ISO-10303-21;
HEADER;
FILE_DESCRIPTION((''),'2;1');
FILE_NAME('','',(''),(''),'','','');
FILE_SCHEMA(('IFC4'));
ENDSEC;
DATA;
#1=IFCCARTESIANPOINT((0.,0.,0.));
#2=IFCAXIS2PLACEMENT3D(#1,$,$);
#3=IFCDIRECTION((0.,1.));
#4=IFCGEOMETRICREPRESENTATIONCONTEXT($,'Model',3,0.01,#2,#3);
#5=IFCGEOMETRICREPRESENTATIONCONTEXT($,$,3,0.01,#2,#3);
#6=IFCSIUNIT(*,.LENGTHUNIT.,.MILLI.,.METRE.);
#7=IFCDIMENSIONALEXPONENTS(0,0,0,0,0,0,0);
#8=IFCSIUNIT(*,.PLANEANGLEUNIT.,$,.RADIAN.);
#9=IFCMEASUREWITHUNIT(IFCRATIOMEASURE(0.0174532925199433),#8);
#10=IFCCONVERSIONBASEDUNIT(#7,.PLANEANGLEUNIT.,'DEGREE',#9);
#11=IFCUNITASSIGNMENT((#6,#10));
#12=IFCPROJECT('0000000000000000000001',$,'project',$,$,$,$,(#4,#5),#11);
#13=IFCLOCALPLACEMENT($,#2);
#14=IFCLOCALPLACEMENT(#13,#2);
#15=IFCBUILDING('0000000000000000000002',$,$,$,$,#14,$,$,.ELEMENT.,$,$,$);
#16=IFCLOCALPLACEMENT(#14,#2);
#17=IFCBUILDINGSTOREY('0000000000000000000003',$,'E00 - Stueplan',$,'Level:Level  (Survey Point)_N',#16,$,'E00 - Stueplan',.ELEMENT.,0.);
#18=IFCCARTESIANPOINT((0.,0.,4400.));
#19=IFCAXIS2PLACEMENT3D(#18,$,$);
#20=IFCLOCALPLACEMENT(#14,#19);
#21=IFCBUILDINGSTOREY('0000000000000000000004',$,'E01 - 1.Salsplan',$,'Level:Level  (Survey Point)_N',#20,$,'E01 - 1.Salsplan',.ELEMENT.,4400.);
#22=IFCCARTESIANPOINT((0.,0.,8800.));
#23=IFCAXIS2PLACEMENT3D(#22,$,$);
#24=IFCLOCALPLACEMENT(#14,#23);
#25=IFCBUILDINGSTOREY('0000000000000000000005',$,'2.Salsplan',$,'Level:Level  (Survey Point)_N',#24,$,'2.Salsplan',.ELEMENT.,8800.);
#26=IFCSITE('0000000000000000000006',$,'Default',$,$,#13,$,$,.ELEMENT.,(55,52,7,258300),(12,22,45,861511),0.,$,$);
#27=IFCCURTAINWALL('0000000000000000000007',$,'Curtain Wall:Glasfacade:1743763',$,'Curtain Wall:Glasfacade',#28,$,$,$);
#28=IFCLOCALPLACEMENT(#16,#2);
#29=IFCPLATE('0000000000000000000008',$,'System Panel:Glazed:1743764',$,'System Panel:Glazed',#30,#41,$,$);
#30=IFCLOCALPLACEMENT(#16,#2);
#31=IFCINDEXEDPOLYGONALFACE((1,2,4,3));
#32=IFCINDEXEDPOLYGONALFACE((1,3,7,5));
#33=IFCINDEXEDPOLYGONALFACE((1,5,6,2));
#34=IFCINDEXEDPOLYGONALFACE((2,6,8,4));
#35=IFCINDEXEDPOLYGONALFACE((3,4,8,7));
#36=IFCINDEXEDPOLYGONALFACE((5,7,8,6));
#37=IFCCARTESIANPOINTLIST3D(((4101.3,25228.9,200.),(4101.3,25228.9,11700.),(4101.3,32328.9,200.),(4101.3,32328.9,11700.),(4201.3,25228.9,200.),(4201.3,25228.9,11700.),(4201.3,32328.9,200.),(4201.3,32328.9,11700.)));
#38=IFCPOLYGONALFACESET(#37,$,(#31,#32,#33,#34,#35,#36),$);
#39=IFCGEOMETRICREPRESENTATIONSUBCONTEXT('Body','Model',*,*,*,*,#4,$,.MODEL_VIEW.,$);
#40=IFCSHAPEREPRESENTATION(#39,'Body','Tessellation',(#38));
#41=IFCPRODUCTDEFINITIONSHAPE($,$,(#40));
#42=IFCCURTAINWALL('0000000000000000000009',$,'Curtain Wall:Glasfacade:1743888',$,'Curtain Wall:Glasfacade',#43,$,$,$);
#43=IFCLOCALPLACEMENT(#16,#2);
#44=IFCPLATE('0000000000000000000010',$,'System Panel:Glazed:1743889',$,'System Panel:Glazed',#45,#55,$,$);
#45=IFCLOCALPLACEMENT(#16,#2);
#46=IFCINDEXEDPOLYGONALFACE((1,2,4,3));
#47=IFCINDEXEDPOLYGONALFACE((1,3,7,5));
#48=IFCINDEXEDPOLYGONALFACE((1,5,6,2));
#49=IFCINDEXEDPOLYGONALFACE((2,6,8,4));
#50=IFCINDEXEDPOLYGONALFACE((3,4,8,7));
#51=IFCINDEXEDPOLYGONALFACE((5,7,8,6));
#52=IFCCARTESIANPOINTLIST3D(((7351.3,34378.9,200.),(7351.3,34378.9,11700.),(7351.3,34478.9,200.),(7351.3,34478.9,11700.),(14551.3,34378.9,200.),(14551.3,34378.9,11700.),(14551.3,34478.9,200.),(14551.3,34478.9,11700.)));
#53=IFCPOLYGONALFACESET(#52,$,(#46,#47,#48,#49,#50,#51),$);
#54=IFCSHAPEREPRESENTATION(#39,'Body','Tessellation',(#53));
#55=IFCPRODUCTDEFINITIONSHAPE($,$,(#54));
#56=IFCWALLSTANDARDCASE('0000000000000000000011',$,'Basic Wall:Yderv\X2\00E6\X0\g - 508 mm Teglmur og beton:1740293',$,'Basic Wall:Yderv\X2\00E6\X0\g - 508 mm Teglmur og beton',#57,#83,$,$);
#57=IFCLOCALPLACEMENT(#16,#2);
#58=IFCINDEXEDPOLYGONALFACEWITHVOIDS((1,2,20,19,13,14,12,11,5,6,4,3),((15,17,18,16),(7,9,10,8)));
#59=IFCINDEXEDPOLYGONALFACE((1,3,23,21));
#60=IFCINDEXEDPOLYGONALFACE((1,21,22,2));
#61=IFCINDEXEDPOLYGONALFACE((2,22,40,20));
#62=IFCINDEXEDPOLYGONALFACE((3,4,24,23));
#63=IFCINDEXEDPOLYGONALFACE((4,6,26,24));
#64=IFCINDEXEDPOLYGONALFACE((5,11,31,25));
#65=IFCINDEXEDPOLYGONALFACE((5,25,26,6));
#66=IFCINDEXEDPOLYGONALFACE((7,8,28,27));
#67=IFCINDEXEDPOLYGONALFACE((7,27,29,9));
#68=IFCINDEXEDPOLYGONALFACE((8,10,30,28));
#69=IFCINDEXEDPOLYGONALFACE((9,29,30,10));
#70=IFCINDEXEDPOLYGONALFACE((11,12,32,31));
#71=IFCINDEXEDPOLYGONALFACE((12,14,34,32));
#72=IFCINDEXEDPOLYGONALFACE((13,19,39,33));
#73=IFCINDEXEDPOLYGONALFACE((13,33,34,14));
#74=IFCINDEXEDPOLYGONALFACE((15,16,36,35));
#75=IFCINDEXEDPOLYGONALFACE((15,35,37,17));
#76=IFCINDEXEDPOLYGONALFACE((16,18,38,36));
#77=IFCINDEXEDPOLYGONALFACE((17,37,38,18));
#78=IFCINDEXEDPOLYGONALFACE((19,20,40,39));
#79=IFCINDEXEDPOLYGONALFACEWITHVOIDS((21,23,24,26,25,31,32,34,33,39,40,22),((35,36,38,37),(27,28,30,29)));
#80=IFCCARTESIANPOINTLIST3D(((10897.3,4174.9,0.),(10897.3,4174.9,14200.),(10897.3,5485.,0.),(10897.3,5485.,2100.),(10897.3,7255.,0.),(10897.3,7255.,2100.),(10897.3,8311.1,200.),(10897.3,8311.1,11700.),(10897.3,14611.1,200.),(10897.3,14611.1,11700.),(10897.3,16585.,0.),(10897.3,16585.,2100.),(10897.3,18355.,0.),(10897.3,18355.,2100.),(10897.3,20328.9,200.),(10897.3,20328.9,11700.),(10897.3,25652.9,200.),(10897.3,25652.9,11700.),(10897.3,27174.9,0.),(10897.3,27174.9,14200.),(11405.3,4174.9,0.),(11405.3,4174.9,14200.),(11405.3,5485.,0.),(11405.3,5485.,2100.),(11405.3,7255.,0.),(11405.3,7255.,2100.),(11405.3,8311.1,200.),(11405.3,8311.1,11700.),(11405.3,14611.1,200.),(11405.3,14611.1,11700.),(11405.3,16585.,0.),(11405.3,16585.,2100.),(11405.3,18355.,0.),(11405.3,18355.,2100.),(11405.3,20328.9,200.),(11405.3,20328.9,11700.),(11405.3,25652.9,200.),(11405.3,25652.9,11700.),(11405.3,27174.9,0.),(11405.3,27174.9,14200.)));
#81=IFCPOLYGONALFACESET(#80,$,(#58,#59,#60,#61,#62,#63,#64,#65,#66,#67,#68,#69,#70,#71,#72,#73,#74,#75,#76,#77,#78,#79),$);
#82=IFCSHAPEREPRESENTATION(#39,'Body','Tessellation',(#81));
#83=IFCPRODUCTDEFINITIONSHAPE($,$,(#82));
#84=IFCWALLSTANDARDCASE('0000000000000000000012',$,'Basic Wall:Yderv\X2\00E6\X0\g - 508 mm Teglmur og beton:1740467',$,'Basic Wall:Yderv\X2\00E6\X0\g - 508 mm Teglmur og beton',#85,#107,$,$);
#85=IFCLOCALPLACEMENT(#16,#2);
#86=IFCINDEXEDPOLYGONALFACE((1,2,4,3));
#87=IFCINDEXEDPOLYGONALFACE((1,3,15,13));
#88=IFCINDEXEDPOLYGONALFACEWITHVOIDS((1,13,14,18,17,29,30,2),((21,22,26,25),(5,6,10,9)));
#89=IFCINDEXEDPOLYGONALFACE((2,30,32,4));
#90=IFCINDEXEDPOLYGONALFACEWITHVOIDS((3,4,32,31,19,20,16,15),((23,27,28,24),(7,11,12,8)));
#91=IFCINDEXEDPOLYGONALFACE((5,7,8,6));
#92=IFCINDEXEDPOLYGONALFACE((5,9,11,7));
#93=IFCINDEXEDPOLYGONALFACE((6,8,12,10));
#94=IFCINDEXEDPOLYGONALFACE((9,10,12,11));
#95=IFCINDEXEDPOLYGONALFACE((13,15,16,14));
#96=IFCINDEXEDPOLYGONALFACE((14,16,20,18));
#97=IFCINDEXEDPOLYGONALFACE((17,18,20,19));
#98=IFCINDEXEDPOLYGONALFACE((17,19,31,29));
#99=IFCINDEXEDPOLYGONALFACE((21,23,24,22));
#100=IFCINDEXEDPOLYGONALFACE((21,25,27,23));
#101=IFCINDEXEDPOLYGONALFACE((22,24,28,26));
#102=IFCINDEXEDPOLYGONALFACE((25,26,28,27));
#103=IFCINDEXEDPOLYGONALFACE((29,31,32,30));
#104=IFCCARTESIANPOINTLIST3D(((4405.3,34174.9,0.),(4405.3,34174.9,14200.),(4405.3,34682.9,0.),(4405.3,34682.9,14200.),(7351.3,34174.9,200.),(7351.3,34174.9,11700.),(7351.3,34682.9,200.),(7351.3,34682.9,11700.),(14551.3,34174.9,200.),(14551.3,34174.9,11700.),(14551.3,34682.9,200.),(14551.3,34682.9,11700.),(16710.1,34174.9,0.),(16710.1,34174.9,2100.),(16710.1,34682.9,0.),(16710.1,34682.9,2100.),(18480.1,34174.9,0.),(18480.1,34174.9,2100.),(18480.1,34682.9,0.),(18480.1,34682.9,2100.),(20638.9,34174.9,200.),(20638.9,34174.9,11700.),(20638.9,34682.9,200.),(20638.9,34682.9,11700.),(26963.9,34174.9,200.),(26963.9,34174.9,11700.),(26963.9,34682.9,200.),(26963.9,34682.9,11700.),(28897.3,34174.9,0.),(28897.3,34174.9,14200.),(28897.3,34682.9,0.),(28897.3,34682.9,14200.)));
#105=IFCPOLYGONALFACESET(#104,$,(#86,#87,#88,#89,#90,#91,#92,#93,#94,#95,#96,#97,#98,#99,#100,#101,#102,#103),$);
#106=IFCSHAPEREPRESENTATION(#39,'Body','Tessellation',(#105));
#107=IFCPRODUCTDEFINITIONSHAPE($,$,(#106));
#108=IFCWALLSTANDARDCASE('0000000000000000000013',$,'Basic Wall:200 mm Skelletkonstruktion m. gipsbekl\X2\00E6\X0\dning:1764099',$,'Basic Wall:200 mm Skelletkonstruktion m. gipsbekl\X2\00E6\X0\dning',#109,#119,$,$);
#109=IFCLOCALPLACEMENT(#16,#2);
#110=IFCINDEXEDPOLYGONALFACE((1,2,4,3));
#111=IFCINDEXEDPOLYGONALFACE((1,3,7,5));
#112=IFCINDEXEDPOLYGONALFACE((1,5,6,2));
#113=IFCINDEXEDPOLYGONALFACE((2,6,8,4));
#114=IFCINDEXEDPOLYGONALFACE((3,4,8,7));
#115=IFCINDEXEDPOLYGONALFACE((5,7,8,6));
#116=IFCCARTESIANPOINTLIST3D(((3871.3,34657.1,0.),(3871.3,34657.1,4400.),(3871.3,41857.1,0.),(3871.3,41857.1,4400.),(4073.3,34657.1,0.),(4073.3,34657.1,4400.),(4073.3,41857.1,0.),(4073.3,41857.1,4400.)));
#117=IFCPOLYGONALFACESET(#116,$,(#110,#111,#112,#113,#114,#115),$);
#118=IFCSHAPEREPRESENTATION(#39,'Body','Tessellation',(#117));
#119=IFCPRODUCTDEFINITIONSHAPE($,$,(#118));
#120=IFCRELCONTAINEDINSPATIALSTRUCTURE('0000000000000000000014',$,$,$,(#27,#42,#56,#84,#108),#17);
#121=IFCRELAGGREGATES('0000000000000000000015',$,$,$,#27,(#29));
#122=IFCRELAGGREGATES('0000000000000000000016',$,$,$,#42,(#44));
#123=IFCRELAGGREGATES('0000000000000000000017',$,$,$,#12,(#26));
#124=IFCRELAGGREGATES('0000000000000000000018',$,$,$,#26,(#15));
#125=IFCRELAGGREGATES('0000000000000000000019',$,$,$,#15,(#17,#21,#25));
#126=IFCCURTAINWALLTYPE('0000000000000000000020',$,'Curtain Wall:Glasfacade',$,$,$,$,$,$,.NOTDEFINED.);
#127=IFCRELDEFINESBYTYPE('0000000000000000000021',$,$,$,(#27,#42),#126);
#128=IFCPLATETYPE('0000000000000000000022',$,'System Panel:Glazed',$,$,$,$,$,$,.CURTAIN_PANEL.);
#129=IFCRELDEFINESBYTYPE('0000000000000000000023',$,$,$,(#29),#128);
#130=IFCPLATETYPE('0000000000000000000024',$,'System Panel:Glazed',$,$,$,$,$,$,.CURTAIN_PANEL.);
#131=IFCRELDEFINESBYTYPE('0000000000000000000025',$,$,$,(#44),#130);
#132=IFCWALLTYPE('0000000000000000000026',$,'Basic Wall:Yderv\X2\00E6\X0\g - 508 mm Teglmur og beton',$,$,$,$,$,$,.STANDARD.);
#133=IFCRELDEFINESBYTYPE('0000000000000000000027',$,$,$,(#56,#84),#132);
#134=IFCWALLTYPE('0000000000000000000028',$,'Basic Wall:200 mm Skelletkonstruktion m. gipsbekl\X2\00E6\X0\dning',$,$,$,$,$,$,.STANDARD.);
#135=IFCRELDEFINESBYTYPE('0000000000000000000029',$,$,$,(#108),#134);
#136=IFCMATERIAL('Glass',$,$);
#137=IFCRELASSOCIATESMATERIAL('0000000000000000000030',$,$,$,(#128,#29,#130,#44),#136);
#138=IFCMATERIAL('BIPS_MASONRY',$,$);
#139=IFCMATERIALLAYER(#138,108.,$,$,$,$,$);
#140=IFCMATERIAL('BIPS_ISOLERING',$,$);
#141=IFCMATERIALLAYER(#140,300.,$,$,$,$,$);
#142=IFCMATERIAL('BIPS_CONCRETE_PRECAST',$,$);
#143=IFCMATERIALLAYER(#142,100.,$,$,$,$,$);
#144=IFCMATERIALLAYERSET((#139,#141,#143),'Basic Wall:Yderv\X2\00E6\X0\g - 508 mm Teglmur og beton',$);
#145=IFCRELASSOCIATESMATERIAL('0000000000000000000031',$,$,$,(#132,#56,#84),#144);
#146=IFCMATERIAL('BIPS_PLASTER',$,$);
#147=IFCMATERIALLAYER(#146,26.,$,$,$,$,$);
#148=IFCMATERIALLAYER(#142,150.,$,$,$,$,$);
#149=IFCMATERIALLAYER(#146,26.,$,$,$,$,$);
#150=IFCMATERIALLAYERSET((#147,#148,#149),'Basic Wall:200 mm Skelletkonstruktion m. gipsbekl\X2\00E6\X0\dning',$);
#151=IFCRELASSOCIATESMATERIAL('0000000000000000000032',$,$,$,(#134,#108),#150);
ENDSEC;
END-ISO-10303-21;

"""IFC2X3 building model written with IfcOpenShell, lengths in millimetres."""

from ifc_helpers import new_model, entity, si_unit, converted_unit, direction, frame, frame_2d, origin, origin_2d_with_axis, place, context, subcontext, project, spatial, rectangle, extrude, source, transform, mapped, material, layer, layer_set, layer_usage, type_object, type_shapes, element, aggregate, save


model = new_model("IFC2X3")

# Units and contexts
model_context = context("Model", 3, precision=0.01, world=origin(), true_north=direction((0.0, 1.0)))
context_of_model = context(None, 3, precision=0.01, world=origin(), true_north=direction((0.0, 1.0)))
body_context = subcontext(model_context, "Body", "Model", "MODEL_VIEW")
ifc_project = project(units=[si_unit("LENGTHUNIT", "METRE", prefix="MILLI"), converted_unit("PLANEANGLEUNIT", "DEGREE", entity("IfcRatioMeasure", 0.0174532925199433), si_unit("PLANEANGLEUNIT", "RADIAN"), dimensions=[0, 0, 0, 0, 0, 0, 0])], contexts=[model_context, context_of_model])

# Site, building, storey
site_placement = place(None, origin())
site = spatial("IfcSite", under=ifc_project, at=site_placement, Name="Default", CompositionType="ELEMENT", RefLatitude=(55, 52, 7, 258300), RefLongitude=(12, 22, 45, 861511), RefElevation=0.0)
building_placement = place(site_placement, origin())
building = spatial("IfcBuilding", under=site, at=building_placement, CompositionType="ELEMENT")
storey_1_placement = place(building_placement, origin())
storey_1 = spatial("IfcBuildingStorey", under=building, at=storey_1_placement, Name="E00 - Stueplan", ObjectType="Level:Level  (Survey Point)_N", LongName="E00 - Stueplan", CompositionType="ELEMENT", Elevation=0.0)

# Curtain walls, plates
curtain_wall_type = type_object("IfcCurtainWallType", Name="Curtain Wall:Glasfacade", PredefinedType="NOTDEFINED")
curtain_wall_1_placement = place(storey_1_placement, origin())
curtain_wall_1 = element("IfcCurtainWall", 1, at=curtain_wall_1_placement, inside=storey_1, type_object=curtain_wall_type, Name="Curtain Wall:Glasfacade:1743763", ObjectType="Curtain Wall:Glasfacade")
ifc_material_1 = material(Name="Glass")
plate_type_1 = type_object("IfcPlateType", Name="System Panel:Glazed", PredefinedType="CURTAIN_PANEL", material=ifc_material_1)
shared_shape_1 = source(origin(), body_context, "Body", "SweptSolid", [
    extrude(rectangle(XDim=100.0, YDim=7100.0, at=origin_2d_with_axis()), frame((0.0, 0.0, 0.0), z_axis=(0.0, 0.0, 1.0), x_axis=(0.0, 1.0, 0.0)), (0.0, 0.0, 1.0), 11500.0),
])
type_shapes(plate_type_1, [shared_shape_1])
plate_1_placement = place(curtain_wall_1_placement, frame((4151.3, 28778.9, 200.0), z_axis=(0.0, 0.0, 1.0), x_axis=(0.0, -1.0, 0.0)))
plate_1 = element("IfcPlate", 2, at=plate_1_placement, type_object=plate_type_1, material=ifc_material_1, Name="System Panel:Glazed:1743764", ObjectType="System Panel:Glazed", context=body_context, shape_type="MappedRepresentation", body=[
    mapped(shared_shape_1, transform((0.0, 0.0, 0.0), scale=1.0)),
])
aggregate(curtain_wall_1, [plate_1])
curtain_wall_2_placement = place(storey_1_placement, origin())
curtain_wall_2 = element("IfcCurtainWall", 3, at=curtain_wall_2_placement, inside=storey_1, type_object=curtain_wall_type, Name="Curtain Wall:Glasfacade:1743888", ObjectType="Curtain Wall:Glasfacade")
plate_type_2 = type_object("IfcPlateType", Name="System Panel:Glazed", PredefinedType="CURTAIN_PANEL", material=ifc_material_1)
shared_shape_2 = source(origin(), body_context, "Body", "SweptSolid", [
    extrude(rectangle(XDim=100.0, YDim=7200.0, at=origin_2d_with_axis()), frame((0.0, 0.0, 0.0), z_axis=(0.0, 0.0, 1.0), x_axis=(0.0, 1.0, 0.0)), (0.0, 0.0, 1.0), 11500.0),
])
type_shapes(plate_type_2, [shared_shape_2])
plate_2_placement = place(curtain_wall_2_placement, frame((10951.3, 34428.9, 200.0)))
plate_2 = element("IfcPlate", 4, at=plate_2_placement, type_object=plate_type_2, material=ifc_material_1, Name="System Panel:Glazed:1743889", ObjectType="System Panel:Glazed", context=body_context, shape_type="MappedRepresentation", body=[
    mapped(shared_shape_2, transform((0.0, 0.0, 0.0), scale=1.0)),
])
aggregate(curtain_wall_2, [plate_2])

# Shared definitions
ifc_material_2 = material(Name="BIPS_MASONRY")
ifc_layer_1 = layer(ifc_material_2, 108.0)
ifc_material_3 = material(Name="BIPS_ISOLERING")
ifc_layer_2 = layer(ifc_material_3, 300.0)
ifc_material_4 = material(Name="BIPS_CONCRETE_PRECAST")
ifc_layer_3 = layer(ifc_material_4, 100.0)
ifc_layer_set_1 = layer_set([ifc_layer_1, ifc_layer_2, ifc_layer_3], Name="Basic Wall:Ydervæg - 508 mm Teglmur og beton")
wall_type_1 = type_object("IfcWallType", Name="Basic Wall:Ydervæg - 508 mm Teglmur og beton", PredefinedType="STANDARD", material=ifc_layer_set_1)

# Shared definitions
storey_2_placement = place(building_placement, frame((0.0, 0.0, 4400.0)))
storey_2 = spatial("IfcBuildingStorey", under=building, at=storey_2_placement, Name="E01 - 1.Salsplan", ObjectType="Level:Level  (Survey Point)_N", LongName="E01 - 1.Salsplan", CompositionType="ELEMENT", Elevation=4400.0)

# Shared definitions
storey_3_placement = place(building_placement, frame((0.0, 0.0, 8800.0)))
storey_3 = spatial("IfcBuildingStorey", under=building, at=storey_3_placement, Name="2.Salsplan", ObjectType="Level:Level  (Survey Point)_N", LongName="2.Salsplan", CompositionType="ELEMENT", Elevation=8800.0)

# Walls, openings
ifc_layer_usage_1 = layer_usage(ifc_layer_set_1, "AXIS2", "POSITIVE", -254.0)
wall_1_placement = place(storey_1_placement, frame((11151.3, 27174.9, 0.0), z_axis=(0.0, 0.0, 1.0), x_axis=(0.0, -1.0, 0.0)))
wall_1 = element("IfcWallStandardCase", 5, at=wall_1_placement, inside=storey_1, type_object=wall_type_1, material=ifc_layer_usage_1, Name="Basic Wall:Ydervæg - 508 mm Teglmur og beton:1740293", ObjectType="Basic Wall:Ydervæg - 508 mm Teglmur og beton", context=body_context, shape_type="SweptSolid", body=[
    extrude(rectangle(XDim=23000.0, YDim=508.0, at=frame_2d((11500.0, 0.0), x_axis=(-1.0, 0.0))), origin(), (0.0, 0.0, 1.0), 14200.0),
])
opening_1_placement = place(wall_1_placement, origin())
element("IfcOpeningElement", 6, at=opening_1_placement, cuts=wall_1, ObjectType="Opening", context=body_context, shape_type="SweptSolid", body=[
    extrude(rectangle(XDim=11500.0, YDim=5324.0, at=frame_2d((0.0, 0.0), x_axis=(1.0, 0.0))), frame((4184.0, -406.4, 5950.0), z_axis=(0.0, 1.0, 0.0), x_axis=(0.0, 0.0, 1.0)), (0.0, 0.0, 1.0), 812.8),
])
opening_2_placement = place(wall_1_placement, origin())
element("IfcOpeningElement", 7, at=opening_2_placement, cuts=wall_1, ObjectType="Opening", context=body_context, shape_type="SweptSolid", body=[
    extrude(rectangle(XDim=11500.0, YDim=6300.0, at=frame_2d((0.0, 0.0), x_axis=(1.0, 0.0))), frame((15713.7, -406.4, 5950.0), z_axis=(0.0, 1.0, 0.0), x_axis=(0.0, 0.0, 1.0)), (0.0, 0.0, 1.0), 812.8),
])
opening_3_placement = place(wall_1_placement, frame((21689.9, 254.0, 0.0)))
element("IfcOpeningElement", 8, at=opening_3_placement, cuts=wall_1, ObjectType="Opening", context=body_context, shape_type="SweptSolid", body=[
    extrude(rectangle(XDim=2100.0, YDim=1770.0, at=frame_2d((1050.0, 885.0), x_axis=(1.0, 0.0))), frame((0.0, 0.0, 0.0), z_axis=(0.0, -1.0, 0.0), x_axis=(0.0, 0.0, 1.0)), (0.0, 0.0, 1.0), 508.0),
])
opening_4_placement = place(wall_1_placement, frame((10589.9, 254.0, 0.0)))
element("IfcOpeningElement", 9, at=opening_4_placement, cuts=wall_1, ObjectType="Opening", context=body_context, shape_type="SweptSolid", body=[
    extrude(rectangle(XDim=2100.0, YDim=1770.0, at=frame_2d((1050.0, 885.0), x_axis=(1.0, 0.0))), frame((0.0, 0.0, 0.0), z_axis=(0.0, -1.0, 0.0), x_axis=(0.0, 0.0, 1.0)), (0.0, 0.0, 1.0), 508.0),
])
ifc_layer_usage_2 = layer_usage(ifc_layer_set_1, "AXIS2", "POSITIVE", -254.0)
wall_2_placement = place(storey_1_placement, frame((4405.3, 34428.9, 0.0)))
wall_2 = element("IfcWallStandardCase", 10, at=wall_2_placement, inside=storey_1, type_object=wall_type_1, material=ifc_layer_usage_2, Name="Basic Wall:Ydervæg - 508 mm Teglmur og beton:1740467", ObjectType="Basic Wall:Ydervæg - 508 mm Teglmur og beton", context=body_context, shape_type="SweptSolid", body=[
    extrude(rectangle(XDim=24492.0, YDim=508.0, at=frame_2d((12246.0, 0.0), x_axis=(-1.0, 0.0))), origin(), (0.0, 0.0, 1.0), 14200.0),
])
opening_5_placement = place(wall_2_placement, origin())
element("IfcOpeningElement", 11, at=opening_5_placement, cuts=wall_2, ObjectType="Opening", context=body_context, shape_type="SweptSolid", body=[
    extrude(rectangle(XDim=11500.0, YDim=7200.0, at=frame_2d((0.0, 0.0), x_axis=(1.0, 0.0))), frame((6546.0, -406.4, 5950.0), z_axis=(0.0, 1.0, 0.0), x_axis=(0.0, 0.0, 1.0)), (0.0, 0.0, 1.0), 812.8),
])
opening_6_placement = place(wall_2_placement, origin())
element("IfcOpeningElement", 12, at=opening_6_placement, cuts=wall_2, ObjectType="Opening", context=body_context, shape_type="SweptSolid", body=[
    extrude(rectangle(XDim=11500.0, YDim=6325.0, at=frame_2d((0.0, 0.0), x_axis=(1.0, 0.0))), frame((19396.1, -406.4, 5950.0), z_axis=(0.0, 1.0, 0.0), x_axis=(0.0, 0.0, 1.0)), (0.0, 0.0, 1.0), 812.8),
])
opening_7_placement = place(wall_2_placement, frame((14074.8, 254.0, 0.0)))
element("IfcOpeningElement", 13, at=opening_7_placement, cuts=wall_2, ObjectType="Opening", context=body_context, shape_type="SweptSolid", body=[
    extrude(rectangle(XDim=2100.0, YDim=1770.0, at=frame_2d((1050.0, 885.0), x_axis=(1.0, 0.0))), frame((0.0, 0.0, 0.0), z_axis=(0.0, -1.0, 0.0), x_axis=(0.0, 0.0, 1.0)), (0.0, 0.0, 1.0), 508.0),
])

# Wall
ifc_material_5 = material(Name="BIPS_PLASTER")
ifc_layer_4 = layer(ifc_material_5, 26.0)
ifc_layer_5 = layer(ifc_material_4, 150.0)
ifc_layer_6 = layer(ifc_material_5, 26.0)
ifc_layer_set_2 = layer_set([ifc_layer_4, ifc_layer_5, ifc_layer_6], Name="Basic Wall:200 mm Skelletkonstruktion m. gipsbeklædning")
ifc_layer_usage_3 = layer_usage(ifc_layer_set_2, "AXIS2", "NEGATIVE", 101.0)
wall_type_2 = type_object("IfcWallType", Name="Basic Wall:200 mm Skelletkonstruktion m. gipsbeklædning", PredefinedType="STANDARD", material=ifc_layer_set_2)
wall_3_placement = place(storey_1_placement, frame((3972.3, 34657.1, 0.0), z_axis=(0.0, 0.0, 1.0), x_axis=(0.0, 1.0, 0.0)))
element("IfcWallStandardCase", 14, at=wall_3_placement, inside=storey_1, type_object=wall_type_2, material=ifc_layer_usage_3, Name="Basic Wall:200 mm Skelletkonstruktion m. gipsbeklædning:1764099", ObjectType="Basic Wall:200 mm Skelletkonstruktion m. gipsbeklædning", context=body_context, shape_type="SweptSolid", body=[
    extrude(rectangle(XDim=7200.0, YDim=202.0, at=frame_2d((3600.0, 0.0), x_axis=(-1.0, 0.0))), origin(), (0.0, 0.0, 1.0), 4400.0),
])

save(model, "model.ifc")
